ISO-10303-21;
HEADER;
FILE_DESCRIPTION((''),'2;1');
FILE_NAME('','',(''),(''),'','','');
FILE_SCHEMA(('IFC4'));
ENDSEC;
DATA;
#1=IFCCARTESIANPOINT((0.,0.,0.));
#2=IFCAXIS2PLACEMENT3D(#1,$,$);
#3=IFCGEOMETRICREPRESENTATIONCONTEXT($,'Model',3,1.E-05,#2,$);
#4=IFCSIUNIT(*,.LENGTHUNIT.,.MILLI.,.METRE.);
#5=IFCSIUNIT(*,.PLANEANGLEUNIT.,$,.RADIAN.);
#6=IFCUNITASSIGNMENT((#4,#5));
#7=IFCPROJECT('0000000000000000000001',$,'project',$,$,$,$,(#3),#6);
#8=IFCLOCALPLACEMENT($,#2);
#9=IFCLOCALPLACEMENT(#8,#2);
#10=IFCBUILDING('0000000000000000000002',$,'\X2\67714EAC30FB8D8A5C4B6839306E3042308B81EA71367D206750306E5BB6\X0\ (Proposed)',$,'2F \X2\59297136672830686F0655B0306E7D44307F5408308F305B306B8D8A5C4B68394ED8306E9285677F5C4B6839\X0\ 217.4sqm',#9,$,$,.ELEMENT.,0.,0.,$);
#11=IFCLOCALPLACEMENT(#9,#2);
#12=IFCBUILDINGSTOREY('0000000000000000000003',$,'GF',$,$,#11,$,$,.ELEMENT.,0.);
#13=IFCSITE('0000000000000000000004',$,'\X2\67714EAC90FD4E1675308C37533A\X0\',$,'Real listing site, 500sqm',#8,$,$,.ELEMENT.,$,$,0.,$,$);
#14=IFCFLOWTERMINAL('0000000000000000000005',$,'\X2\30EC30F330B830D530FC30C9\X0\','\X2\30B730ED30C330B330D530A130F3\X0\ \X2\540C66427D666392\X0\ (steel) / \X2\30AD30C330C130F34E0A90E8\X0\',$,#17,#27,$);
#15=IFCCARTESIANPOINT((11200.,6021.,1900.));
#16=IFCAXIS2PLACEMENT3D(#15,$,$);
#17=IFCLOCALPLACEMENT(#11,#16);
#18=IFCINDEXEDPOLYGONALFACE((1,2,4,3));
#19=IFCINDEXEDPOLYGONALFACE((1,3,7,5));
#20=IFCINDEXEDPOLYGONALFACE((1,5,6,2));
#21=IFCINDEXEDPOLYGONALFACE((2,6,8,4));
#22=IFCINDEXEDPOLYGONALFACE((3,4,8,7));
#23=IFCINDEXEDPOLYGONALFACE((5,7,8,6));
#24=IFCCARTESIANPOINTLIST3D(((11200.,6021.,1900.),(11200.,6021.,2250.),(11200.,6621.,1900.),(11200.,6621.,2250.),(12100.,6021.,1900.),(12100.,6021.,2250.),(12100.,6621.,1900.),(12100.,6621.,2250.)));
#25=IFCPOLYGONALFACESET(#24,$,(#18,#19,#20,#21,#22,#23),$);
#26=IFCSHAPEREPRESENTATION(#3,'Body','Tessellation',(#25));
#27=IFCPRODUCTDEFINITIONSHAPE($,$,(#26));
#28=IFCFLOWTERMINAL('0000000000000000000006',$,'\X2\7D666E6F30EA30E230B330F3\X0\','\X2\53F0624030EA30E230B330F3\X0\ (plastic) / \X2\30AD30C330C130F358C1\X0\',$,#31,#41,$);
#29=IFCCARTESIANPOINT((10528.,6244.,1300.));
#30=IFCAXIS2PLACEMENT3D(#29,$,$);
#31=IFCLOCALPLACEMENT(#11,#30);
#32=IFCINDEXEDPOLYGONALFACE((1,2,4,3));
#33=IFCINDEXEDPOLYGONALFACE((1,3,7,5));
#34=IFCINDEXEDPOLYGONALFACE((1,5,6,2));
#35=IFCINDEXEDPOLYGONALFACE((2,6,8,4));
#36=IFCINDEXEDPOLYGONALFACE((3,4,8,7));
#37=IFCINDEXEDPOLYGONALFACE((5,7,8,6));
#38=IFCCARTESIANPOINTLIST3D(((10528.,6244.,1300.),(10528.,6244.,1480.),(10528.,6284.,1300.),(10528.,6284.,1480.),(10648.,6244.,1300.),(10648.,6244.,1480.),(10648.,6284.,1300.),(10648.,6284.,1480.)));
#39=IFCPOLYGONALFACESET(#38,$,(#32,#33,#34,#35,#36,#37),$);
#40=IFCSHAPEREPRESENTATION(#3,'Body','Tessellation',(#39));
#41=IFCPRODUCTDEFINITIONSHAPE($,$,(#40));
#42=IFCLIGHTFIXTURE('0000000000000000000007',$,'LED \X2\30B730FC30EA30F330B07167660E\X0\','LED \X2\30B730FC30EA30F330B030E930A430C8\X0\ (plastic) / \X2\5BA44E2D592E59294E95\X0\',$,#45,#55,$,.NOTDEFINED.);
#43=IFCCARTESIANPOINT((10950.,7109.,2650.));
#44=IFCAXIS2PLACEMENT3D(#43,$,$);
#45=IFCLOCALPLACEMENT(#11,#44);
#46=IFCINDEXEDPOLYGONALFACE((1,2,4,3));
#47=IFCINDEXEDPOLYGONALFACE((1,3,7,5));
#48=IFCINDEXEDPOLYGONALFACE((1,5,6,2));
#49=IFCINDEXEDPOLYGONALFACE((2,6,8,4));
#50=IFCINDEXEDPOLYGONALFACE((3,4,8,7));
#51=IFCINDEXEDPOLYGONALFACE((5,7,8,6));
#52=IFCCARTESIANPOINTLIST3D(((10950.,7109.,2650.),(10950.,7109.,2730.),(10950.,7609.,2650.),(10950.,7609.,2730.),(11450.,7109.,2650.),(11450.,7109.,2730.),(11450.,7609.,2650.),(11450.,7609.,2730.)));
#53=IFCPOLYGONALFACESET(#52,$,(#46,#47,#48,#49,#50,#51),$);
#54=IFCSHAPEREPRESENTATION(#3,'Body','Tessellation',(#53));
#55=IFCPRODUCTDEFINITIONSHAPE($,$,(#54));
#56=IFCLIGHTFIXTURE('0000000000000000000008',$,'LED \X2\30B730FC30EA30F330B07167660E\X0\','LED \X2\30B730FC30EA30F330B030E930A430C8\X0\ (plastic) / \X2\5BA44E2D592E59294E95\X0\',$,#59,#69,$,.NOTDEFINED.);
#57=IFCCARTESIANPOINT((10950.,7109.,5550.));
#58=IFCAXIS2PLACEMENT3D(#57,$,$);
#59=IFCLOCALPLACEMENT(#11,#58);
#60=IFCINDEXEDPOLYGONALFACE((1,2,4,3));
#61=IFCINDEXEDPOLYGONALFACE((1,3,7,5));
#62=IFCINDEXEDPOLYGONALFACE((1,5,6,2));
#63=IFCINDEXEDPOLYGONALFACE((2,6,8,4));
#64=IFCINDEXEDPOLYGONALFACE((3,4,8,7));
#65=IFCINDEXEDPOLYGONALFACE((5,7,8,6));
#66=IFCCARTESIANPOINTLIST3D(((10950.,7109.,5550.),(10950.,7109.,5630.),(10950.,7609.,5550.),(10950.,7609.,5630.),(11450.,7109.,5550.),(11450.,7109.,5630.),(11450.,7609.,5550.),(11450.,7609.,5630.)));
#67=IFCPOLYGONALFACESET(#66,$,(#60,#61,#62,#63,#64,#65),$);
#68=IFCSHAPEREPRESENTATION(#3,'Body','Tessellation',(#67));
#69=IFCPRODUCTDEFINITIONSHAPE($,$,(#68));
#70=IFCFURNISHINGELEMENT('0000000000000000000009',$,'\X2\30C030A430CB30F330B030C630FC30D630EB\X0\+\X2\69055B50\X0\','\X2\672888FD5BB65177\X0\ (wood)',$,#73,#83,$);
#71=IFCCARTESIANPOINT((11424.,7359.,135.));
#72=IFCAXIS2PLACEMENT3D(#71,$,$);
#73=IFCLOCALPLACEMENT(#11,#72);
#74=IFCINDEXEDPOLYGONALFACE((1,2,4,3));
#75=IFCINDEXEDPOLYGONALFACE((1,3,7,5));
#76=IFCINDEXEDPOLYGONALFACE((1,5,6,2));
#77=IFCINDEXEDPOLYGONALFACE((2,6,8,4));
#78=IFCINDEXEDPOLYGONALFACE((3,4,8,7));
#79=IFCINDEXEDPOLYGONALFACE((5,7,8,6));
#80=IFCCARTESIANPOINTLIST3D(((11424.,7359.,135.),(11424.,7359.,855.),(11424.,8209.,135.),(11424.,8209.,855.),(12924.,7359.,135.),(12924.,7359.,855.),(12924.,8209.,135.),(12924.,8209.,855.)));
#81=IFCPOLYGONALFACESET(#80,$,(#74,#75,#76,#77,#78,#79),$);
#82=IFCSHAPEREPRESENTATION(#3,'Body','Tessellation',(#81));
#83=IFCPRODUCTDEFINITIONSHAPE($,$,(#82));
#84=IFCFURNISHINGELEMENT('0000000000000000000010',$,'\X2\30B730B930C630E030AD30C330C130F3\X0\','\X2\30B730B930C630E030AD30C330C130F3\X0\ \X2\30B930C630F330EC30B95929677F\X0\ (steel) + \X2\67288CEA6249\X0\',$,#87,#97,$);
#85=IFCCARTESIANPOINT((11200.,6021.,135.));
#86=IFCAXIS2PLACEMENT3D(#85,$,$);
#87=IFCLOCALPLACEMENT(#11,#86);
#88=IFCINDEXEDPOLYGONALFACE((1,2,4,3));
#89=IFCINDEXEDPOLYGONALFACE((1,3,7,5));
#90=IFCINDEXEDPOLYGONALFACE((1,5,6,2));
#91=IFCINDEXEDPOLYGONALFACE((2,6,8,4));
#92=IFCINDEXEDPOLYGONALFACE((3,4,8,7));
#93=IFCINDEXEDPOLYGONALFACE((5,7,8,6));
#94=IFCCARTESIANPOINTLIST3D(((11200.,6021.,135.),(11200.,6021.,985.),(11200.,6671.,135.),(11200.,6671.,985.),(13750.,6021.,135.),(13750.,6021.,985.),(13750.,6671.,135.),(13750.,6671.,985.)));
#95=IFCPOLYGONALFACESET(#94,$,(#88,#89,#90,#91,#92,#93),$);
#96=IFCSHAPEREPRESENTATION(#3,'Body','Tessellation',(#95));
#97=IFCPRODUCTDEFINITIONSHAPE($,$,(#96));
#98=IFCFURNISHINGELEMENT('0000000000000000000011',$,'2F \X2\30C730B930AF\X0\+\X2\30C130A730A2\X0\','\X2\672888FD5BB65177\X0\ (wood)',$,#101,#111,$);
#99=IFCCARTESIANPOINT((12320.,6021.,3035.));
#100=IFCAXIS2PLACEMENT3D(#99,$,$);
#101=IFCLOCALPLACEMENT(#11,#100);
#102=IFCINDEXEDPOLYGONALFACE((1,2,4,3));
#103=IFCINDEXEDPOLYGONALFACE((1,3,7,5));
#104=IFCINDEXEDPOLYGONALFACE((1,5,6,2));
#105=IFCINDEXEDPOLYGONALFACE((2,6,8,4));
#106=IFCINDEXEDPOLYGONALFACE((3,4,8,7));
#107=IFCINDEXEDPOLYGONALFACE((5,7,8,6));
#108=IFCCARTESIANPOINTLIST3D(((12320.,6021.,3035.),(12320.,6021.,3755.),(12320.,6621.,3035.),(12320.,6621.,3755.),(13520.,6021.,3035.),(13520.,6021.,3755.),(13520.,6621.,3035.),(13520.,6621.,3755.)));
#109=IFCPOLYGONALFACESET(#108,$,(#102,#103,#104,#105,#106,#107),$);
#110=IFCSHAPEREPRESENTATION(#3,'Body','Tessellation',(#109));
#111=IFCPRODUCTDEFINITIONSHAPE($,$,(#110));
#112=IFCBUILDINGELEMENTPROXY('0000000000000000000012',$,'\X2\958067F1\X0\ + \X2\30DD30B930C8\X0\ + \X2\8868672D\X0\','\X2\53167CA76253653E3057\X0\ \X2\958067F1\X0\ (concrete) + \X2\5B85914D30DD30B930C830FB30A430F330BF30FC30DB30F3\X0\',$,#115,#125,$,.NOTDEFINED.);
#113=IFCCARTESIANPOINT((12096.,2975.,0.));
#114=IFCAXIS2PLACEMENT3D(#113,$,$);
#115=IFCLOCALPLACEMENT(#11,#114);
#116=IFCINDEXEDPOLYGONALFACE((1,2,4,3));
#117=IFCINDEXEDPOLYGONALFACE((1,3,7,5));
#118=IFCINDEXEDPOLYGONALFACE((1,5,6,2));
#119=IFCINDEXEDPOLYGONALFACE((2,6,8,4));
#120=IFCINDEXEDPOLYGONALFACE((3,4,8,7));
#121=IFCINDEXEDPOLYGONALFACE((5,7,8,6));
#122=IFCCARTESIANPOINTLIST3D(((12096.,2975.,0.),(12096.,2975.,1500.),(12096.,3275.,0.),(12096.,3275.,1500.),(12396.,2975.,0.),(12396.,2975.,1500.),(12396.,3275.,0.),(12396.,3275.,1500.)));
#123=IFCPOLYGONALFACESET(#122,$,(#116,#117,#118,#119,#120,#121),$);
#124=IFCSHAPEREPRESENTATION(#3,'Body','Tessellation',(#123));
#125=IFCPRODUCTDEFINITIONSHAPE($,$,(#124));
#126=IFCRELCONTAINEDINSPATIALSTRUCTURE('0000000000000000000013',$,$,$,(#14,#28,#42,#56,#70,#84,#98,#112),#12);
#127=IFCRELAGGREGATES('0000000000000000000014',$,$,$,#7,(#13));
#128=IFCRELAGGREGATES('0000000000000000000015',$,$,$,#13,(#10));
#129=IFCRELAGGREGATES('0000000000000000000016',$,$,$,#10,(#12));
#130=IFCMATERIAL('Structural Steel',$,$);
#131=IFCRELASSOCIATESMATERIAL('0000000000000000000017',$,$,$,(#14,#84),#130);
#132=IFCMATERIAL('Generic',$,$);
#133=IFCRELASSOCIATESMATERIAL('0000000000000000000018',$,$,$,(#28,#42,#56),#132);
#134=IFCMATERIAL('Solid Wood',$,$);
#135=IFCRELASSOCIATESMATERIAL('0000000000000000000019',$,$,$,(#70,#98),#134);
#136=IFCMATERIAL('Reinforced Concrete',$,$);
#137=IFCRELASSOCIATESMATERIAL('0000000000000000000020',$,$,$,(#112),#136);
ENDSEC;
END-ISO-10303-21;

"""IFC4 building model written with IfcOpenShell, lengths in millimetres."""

from ifc_helpers import new_model, si_unit, frame, frame_2d, origin, place, context, project, spatial, rectangle, extrude, material, element, save


model = new_model("IFC4")

# Units and contexts
model_context = context("Model", 3, precision=1e-05, world=origin())
ifc_project = project(units=[si_unit("LENGTHUNIT", "METRE", prefix="MILLI"), si_unit("PLANEANGLEUNIT", "RADIAN")], contexts=[model_context])

# Site, building, storey
site_placement = place(None, origin())
site = spatial("IfcSite", under=ifc_project, at=site_placement, Name="東京都世田谷区", ObjectType="Real listing site, 500sqm", CompositionType="ELEMENT", RefElevation=0.0)
building_placement = place(site_placement, origin())
building = spatial("IfcBuilding", under=site, at=building_placement, Name="東京・越屋根のある自然素材の家 (Proposed)", ObjectType="2F 天然木と漆喰の組み合わせに越屋根付の銅板屋根 217.4sqm", CompositionType="ELEMENT", ElevationOfRefHeight=0.0, ElevationOfTerrain=0.0)
storey_placement = place(building_placement, origin())
storey = spatial("IfcBuildingStorey", under=building, at=storey_placement, Name="GF", CompositionType="ELEMENT", Elevation=0.0)

# Shared definitions
ifc_material_1 = material(Name="Solid Wood")

# Shared definitions
ifc_material_2 = material(Name="Structural Steel")

# Shared definitions
ifc_material_3 = material(Name="Reinforced Concrete")

# Flow terminals
flow_terminal_1_placement = place(storey_placement, frame((11200.0, 6021.0, 1900.0)))
element("IfcFlowTerminal", 1, at=flow_terminal_1_placement, inside=storey, material=ifc_material_2, Name="レンジフード", Description="シロッコファン 同時給排 (steel) / キッチン上部", context=model_context, shape_type="SweptSolid", body=[
    extrude(rectangle(XDim=900.0, YDim=600.0, at=frame_2d((450.0, 300.0))), frame((11200.0, 6021.0, 1900.0)), (0.0, 0.0, 1.0), 350.0),
])
ifc_material_4 = material(Name="Generic")
flow_terminal_2_placement = place(storey_placement, frame((10528.0, 6244.0, 1300.0)))
element("IfcFlowTerminal", 2, at=flow_terminal_2_placement, inside=storey, material=ifc_material_4, Name="給湯リモコン", Description="台所リモコン (plastic) / キッチン壁", context=model_context, shape_type="SweptSolid", body=[
    extrude(rectangle(XDim=120.0, YDim=40.0, at=frame_2d((60.0, 20.0))), frame((10528.0, 6244.0, 1300.0)), (0.0, 0.0, 1.0), 180.0),
])

# Light fixtures
light_fixture_1_placement = place(storey_placement, frame((10950.0, 7109.0, 2650.0)))
element("IfcLightFixture", 3, at=light_fixture_1_placement, inside=storey, material=ifc_material_4, Name="LED シーリング照明", Description="LED シーリングライト (plastic) / 室中央天井", PredefinedType="NOTDEFINED", context=model_context, shape_type="SweptSolid", body=[
    extrude(rectangle(XDim=500.0, YDim=500.0, at=frame_2d((250.0, 250.0))), frame((10950.0, 7109.0, 2650.0)), (0.0, 0.0, 1.0), 80.0),
])
light_fixture_2_placement = place(storey_placement, frame((10950.0, 7109.0, 5550.0)))
element("IfcLightFixture", 4, at=light_fixture_2_placement, inside=storey, material=ifc_material_4, Name="LED シーリング照明", Description="LED シーリングライト (plastic) / 室中央天井", PredefinedType="NOTDEFINED", context=model_context, shape_type="SweptSolid", body=[
    extrude(rectangle(XDim=500.0, YDim=500.0, at=frame_2d((250.0, 250.0))), frame((10950.0, 7109.0, 5550.0)), (0.0, 0.0, 1.0), 80.0),
])

# Furnishing elements
furnishing_1_placement = place(storey_placement, frame((11424.0, 7359.0, 135.0)))
element("IfcFurnishingElement", 5, at=furnishing_1_placement, inside=storey, material=ifc_material_1, Name="ダイニングテーブル+椅子", Description="木製家具 (wood)", context=model_context, shape_type="SweptSolid", body=[
    extrude(rectangle(XDim=1500.0, YDim=850.0, at=frame_2d((750.0, 425.0))), frame((11424.0, 7359.0, 135.0)), (0.0, 0.0, 1.0), 720.0),
])
furnishing_2_placement = place(storey_placement, frame((11200.0, 6021.0, 135.0)))
element("IfcFurnishingElement", 6, at=furnishing_2_placement, inside=storey, material=ifc_material_2, Name="システムキッチン", Description="システムキッチン ステンレス天板 (steel) + 木質扉", context=model_context, shape_type="SweptSolid", body=[
    extrude(rectangle(XDim=2550.0, YDim=650.0, at=frame_2d((1275.0, 325.0))), frame((11200.0, 6021.0, 135.0)), (0.0, 0.0, 1.0), 850.0),
])
furnishing_3_placement = place(storey_placement, frame((12320.0, 6021.0, 3035.0)))
element("IfcFurnishingElement", 7, at=furnishing_3_placement, inside=storey, material=ifc_material_1, Name="2F デスク+チェア", Description="木製家具 (wood)", context=model_context, shape_type="SweptSolid", body=[
    extrude(rectangle(XDim=1200.0, YDim=600.0, at=frame_2d((600.0, 300.0))), frame((12320.0, 6021.0, 3035.0)), (0.0, 0.0, 1.0), 720.0),
])

# Building element proxy
proxy_placement = place(storey_placement, frame((12096.0, 2975.0, 0.0)))
element("IfcBuildingElementProxy", 8, at=proxy_placement, inside=storey, material=ifc_material_3, Name="門柱 + ポスト + 表札", Description="化粧打放し 門柱 (concrete) + 宅配ポスト・インターホン", PredefinedType="NOTDEFINED", context=model_context, shape_type="SweptSolid", body=[
    extrude(rectangle(XDim=300.0, YDim=300.0, at=frame_2d((150.0, 150.0))), frame((12096.0, 2975.0, 0.0)), (0.0, 0.0, 1.0), 1500.0),
])

save(model, "model.ifc")
